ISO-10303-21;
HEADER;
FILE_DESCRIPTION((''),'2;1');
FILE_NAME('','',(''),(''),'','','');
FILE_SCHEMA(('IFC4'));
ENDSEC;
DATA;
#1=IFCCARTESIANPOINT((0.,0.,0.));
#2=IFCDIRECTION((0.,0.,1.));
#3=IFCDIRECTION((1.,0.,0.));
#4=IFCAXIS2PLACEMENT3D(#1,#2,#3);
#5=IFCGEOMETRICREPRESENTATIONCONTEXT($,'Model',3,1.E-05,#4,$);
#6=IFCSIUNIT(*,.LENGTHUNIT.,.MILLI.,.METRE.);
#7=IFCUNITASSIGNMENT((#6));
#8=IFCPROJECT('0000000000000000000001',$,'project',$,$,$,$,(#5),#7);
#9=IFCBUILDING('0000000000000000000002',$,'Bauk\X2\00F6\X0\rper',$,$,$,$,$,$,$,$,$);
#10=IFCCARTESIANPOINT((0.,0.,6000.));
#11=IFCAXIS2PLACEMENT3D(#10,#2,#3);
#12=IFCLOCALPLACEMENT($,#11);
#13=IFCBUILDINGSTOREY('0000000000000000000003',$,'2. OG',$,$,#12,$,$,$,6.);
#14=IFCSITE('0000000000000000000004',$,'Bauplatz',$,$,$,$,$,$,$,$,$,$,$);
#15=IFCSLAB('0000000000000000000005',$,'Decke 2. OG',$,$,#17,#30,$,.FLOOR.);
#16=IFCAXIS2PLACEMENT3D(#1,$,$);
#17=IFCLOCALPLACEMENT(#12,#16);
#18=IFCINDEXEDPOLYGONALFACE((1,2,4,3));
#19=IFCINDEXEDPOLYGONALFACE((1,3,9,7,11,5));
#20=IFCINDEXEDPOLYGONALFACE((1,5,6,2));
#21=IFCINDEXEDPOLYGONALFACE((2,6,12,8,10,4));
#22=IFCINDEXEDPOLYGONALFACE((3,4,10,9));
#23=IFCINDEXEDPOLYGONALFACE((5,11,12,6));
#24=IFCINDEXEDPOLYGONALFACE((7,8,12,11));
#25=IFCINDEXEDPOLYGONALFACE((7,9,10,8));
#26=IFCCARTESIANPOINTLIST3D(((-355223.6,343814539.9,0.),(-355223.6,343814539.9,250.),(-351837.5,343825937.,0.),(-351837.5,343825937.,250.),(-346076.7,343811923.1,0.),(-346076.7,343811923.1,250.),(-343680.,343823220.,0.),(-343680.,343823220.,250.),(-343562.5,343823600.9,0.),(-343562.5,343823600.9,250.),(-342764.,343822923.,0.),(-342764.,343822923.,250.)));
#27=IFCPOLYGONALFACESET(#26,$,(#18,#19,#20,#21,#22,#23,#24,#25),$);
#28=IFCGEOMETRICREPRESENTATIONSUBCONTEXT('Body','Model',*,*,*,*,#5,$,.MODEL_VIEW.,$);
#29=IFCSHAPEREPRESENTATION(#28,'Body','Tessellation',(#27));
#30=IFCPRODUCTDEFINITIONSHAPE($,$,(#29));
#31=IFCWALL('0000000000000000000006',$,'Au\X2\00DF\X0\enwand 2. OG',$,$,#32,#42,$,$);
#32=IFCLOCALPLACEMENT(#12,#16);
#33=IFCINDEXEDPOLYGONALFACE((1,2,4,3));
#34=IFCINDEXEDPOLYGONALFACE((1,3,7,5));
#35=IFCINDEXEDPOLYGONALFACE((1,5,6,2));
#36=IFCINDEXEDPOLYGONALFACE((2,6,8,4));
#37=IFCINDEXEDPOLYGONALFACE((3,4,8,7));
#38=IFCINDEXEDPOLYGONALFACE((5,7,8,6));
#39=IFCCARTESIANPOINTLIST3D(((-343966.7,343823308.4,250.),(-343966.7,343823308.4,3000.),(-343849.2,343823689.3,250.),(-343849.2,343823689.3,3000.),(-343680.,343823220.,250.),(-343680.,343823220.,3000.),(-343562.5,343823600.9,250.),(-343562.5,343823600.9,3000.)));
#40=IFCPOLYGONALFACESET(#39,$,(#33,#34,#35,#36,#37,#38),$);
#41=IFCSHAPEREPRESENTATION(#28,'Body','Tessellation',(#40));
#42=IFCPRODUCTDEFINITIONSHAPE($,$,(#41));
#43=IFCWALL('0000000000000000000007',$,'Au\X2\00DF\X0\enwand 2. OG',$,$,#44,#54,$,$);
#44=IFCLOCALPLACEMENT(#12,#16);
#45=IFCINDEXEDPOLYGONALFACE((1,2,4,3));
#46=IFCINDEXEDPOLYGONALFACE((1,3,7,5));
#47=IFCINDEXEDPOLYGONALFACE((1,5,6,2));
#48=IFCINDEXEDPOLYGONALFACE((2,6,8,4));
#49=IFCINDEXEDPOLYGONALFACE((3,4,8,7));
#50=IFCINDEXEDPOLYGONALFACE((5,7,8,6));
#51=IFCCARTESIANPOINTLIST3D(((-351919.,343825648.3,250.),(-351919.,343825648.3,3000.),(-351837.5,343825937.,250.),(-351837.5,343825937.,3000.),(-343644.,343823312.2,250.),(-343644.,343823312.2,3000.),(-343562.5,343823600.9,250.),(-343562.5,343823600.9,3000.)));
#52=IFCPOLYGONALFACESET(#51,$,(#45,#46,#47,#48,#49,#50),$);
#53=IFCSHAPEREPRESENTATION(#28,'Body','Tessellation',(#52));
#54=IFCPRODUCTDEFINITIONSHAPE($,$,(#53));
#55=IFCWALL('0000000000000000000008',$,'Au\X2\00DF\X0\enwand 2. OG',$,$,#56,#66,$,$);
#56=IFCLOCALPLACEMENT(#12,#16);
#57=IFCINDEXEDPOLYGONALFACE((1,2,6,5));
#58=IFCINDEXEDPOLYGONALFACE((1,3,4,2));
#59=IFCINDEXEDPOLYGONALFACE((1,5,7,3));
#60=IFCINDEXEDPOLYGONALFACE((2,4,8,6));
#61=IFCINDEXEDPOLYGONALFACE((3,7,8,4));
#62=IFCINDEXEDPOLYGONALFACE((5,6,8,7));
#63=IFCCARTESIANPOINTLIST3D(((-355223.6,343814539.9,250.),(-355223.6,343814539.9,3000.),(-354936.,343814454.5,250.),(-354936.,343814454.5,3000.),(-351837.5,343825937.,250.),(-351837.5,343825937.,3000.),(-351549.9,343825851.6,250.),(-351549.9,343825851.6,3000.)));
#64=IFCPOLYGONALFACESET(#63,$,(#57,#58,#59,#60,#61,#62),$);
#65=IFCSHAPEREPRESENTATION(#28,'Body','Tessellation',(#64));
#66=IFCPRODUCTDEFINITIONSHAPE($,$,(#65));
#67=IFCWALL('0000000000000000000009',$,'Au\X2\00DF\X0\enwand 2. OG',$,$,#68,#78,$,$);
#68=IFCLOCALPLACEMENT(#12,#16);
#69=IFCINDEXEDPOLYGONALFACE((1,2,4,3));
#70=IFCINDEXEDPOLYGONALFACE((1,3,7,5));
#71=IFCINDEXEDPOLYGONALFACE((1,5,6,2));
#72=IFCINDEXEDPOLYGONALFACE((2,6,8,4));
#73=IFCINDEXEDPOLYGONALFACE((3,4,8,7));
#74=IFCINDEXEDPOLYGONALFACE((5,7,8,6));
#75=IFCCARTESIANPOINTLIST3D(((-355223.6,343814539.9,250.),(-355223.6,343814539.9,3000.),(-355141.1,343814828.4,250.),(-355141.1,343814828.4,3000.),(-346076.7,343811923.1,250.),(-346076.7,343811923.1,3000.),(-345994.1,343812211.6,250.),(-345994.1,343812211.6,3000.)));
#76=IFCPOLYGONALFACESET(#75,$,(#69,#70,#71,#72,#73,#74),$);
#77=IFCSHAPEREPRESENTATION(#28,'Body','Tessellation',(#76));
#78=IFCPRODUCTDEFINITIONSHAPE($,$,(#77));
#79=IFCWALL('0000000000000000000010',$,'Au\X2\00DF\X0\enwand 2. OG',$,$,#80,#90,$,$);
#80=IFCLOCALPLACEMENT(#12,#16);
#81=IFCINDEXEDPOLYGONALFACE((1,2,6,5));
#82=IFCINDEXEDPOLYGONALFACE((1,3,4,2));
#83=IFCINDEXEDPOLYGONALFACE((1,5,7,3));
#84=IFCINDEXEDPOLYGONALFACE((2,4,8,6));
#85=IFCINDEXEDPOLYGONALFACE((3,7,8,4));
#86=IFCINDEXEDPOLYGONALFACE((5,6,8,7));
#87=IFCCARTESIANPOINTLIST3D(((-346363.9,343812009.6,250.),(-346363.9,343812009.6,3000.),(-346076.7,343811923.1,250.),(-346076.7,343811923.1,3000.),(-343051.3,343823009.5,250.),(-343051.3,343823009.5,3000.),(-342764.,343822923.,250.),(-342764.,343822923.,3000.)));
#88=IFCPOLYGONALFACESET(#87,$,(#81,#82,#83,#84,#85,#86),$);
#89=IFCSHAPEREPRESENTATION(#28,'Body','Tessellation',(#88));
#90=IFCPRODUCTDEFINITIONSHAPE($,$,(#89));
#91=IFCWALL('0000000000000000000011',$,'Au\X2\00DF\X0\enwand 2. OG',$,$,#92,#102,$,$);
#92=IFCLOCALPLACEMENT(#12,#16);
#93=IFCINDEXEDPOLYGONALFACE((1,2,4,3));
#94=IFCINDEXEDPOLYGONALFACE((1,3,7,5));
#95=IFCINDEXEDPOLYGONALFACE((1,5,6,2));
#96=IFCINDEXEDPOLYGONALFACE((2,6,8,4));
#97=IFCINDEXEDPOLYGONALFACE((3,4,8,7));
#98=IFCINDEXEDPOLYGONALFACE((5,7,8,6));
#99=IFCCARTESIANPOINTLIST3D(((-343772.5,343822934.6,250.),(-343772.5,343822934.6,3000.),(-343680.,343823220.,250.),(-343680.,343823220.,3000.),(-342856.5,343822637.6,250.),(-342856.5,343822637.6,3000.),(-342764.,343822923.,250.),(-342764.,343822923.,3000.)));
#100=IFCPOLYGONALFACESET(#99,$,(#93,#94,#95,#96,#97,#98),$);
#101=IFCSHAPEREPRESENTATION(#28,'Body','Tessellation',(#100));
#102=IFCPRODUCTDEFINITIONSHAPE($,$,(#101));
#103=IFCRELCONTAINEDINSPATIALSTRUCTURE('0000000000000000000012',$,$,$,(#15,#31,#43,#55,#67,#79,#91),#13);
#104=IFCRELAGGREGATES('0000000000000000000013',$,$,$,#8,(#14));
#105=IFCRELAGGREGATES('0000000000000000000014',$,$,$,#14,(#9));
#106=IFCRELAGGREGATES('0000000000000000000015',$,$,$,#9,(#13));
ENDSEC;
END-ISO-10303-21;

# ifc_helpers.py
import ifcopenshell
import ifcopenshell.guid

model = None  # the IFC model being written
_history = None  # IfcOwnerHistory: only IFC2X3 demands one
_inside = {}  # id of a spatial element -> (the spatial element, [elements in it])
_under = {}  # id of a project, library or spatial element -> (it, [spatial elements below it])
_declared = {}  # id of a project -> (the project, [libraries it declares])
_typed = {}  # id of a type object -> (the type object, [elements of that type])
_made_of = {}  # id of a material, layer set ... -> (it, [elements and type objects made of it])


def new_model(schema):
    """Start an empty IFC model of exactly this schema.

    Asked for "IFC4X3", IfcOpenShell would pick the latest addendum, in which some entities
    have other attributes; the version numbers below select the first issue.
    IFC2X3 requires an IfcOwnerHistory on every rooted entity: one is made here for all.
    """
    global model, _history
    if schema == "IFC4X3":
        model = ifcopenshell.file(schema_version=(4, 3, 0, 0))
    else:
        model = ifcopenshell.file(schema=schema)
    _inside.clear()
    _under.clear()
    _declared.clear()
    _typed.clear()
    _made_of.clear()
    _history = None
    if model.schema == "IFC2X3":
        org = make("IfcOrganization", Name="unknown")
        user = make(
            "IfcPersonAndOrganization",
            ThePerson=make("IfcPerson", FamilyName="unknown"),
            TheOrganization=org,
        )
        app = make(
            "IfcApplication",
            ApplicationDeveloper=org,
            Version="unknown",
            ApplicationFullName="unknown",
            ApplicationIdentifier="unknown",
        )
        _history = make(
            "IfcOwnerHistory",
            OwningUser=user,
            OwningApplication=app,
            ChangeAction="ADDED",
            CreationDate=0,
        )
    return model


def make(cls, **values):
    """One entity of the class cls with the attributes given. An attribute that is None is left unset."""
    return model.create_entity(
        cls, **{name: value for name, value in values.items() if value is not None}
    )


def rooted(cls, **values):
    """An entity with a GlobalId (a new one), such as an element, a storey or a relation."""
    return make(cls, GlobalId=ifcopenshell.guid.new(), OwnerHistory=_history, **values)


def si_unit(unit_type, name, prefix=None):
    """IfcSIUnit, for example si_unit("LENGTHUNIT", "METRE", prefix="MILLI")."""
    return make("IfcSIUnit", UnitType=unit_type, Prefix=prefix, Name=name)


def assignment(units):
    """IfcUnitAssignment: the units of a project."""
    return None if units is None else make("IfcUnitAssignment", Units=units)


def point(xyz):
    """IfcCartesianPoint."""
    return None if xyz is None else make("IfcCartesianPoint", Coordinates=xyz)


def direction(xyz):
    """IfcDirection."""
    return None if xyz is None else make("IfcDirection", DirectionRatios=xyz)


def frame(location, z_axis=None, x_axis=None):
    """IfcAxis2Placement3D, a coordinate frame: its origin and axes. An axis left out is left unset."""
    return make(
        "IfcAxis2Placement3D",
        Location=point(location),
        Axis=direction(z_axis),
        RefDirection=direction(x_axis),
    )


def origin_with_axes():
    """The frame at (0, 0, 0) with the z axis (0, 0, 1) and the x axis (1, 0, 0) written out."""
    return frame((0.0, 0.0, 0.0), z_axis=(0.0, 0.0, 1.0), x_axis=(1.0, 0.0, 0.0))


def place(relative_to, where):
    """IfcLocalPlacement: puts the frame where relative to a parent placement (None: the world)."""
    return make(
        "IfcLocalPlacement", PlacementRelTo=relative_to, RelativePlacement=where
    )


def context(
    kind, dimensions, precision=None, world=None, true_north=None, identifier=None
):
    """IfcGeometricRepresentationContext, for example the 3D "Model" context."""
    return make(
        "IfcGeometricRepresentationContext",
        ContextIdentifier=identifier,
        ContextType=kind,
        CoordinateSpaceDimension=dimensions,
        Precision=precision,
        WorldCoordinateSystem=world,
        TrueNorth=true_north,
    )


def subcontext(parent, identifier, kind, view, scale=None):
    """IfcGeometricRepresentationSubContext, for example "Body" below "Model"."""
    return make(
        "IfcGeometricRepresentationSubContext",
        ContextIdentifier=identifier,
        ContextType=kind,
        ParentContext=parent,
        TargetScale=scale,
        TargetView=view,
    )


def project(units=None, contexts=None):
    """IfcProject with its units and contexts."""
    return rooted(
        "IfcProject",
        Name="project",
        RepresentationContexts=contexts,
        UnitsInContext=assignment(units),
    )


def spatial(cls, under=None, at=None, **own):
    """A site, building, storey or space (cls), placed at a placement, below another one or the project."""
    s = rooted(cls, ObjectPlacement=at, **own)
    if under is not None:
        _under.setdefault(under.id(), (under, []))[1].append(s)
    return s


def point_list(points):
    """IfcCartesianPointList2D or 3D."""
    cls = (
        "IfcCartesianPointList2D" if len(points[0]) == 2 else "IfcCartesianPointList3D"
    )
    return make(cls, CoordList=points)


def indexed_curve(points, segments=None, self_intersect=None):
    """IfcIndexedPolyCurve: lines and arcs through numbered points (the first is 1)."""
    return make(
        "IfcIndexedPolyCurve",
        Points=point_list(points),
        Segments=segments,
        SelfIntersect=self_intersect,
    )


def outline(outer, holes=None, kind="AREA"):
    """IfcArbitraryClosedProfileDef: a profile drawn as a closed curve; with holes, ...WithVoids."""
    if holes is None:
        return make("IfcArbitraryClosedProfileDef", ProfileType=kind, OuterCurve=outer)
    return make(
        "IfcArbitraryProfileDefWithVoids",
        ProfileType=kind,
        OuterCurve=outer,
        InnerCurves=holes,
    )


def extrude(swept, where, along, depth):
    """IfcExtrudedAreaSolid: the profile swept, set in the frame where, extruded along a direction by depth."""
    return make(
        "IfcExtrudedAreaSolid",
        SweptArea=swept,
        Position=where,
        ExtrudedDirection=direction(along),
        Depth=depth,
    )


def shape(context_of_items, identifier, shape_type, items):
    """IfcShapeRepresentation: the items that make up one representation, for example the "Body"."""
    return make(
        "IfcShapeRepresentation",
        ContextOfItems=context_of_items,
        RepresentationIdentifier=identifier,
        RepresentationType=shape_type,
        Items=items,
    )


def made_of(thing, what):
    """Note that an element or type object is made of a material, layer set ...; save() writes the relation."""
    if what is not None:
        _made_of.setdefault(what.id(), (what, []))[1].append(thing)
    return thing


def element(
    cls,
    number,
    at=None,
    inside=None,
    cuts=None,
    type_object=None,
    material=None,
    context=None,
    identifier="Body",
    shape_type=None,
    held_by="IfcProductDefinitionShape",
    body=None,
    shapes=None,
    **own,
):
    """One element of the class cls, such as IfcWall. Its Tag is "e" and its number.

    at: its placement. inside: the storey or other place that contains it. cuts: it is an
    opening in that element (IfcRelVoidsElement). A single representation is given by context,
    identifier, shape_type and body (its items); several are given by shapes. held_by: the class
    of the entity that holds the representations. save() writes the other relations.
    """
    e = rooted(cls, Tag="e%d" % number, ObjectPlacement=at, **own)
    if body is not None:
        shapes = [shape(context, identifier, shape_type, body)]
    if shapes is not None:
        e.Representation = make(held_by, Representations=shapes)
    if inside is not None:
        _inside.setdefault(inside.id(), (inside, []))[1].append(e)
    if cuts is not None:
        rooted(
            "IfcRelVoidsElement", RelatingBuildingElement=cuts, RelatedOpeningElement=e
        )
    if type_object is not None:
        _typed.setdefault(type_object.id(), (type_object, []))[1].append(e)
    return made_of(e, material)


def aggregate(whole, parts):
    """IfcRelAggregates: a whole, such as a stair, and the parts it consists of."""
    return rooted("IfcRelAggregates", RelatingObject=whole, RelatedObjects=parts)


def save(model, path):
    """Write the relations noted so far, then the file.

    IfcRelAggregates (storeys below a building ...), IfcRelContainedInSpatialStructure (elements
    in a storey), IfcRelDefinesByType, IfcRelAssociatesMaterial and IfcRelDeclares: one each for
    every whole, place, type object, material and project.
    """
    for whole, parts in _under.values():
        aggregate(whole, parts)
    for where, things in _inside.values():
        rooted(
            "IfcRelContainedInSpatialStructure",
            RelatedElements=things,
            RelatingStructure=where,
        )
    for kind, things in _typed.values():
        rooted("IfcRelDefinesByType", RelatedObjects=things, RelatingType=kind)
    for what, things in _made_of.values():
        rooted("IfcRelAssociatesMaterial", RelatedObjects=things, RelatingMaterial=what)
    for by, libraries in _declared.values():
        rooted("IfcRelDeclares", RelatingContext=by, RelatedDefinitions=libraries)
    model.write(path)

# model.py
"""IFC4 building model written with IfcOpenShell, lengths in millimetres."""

from ifc_helpers import new_model, si_unit, frame, origin_with_axes, place, context, subcontext, project, spatial, indexed_curve, outline, extrude, element, save


model = new_model("IFC4")

# Units and contexts
model_context = context("Model", 3, precision=1e-05, world=origin_with_axes())
body_context = subcontext(model_context, "Body", "Model", "MODEL_VIEW")
ifc_project = project(units=[si_unit("LENGTHUNIT", "METRE", prefix="MILLI")], contexts=[model_context])

# Site, building, storey
site = spatial("IfcSite", under=ifc_project, Name="Bauplatz")
building = spatial("IfcBuilding", under=site, Name="Baukörper")
storey_placement = place(None, frame((0.0, 0.0, 6000.0), z_axis=(0.0, 0.0, 1.0), x_axis=(1.0, 0.0, 0.0)))
storey = spatial("IfcBuildingStorey", under=building, at=storey_placement, Name="2. OG", Elevation=6.0)

# Slab
slab_placement = place(storey_placement, origin_with_axes())
element("IfcSlab", 1, at=slab_placement, inside=storey, Name="Decke 2. OG", PredefinedType="FLOOR", context=body_context, shape_type="SweptSolid", body=[
    extrude(outline(indexed_curve([(-343680.0, 343823220.0), (-342764.0, 343822923.0), (-346076.7, 343811923.1), (-355223.6, 343814539.9), (-351837.5, 343825937.0), (-343562.5, 343823600.9)])), None, (0.0, 0.0, 1.0), 250.0),
])

# Walls
wall_1_placement = place(storey_placement, frame((-343680.0, 343823220.0, 250.0), z_axis=(0.0, 0.0, 1.0), x_axis=(0.294713, 0.955586, 0.0)))
element("IfcWall", 2, at=wall_1_placement, inside=storey, Name="Außenwand 2. OG", context=body_context, shape_type="SweptSolid", body=[
    extrude(outline(indexed_curve([(0.0, 0.0), (0.0, 300.0), (398.6, 300.0), (398.6, 0.0), (0.0, 0.0)], self_intersect=False)), origin_with_axes(), (0.0, 0.0, 1.0), 2750.0),
])
wall_2_placement = place(storey_placement, frame((-343562.5, 343823600.9, 250.0), z_axis=(0.0, 0.0, 1.0), x_axis=(-0.962385, 0.271691, 0.0)))
element("IfcWall", 3, at=wall_2_placement, inside=storey, Name="Außenwand 2. OG", context=body_context, shape_type="SweptSolid", body=[
    extrude(outline(indexed_curve([(0.0, 0.0), (0.0, 300.0), (8598.4, 300.0), (8598.4, 0.0), (0.0, 0.0)], self_intersect=False)), origin_with_axes(), (0.0, 0.0, 1.0), 2750.0),
])
wall_3_placement = place(storey_placement, frame((-351837.5, 343825937.0, 250.0), z_axis=(0.0, 0.0, 1.0), x_axis=(-0.284796, -0.958588, 0.0)))
element("IfcWall", 4, at=wall_3_placement, inside=storey, Name="Außenwand 2. OG", context=body_context, shape_type="SweptSolid", body=[
    extrude(outline(indexed_curve([(0.0, 0.0), (0.0, 300.0), (11889.4, 300.0), (11889.4, 0.0), (0.0, 0.0)], self_intersect=False)), origin_with_axes(), (0.0, 0.0, 1.0), 2750.0),
])
wall_4_placement = place(storey_placement, frame((-355223.6, 343814539.9, 250.0), z_axis=(0.0, 0.0, 1.0), x_axis=(0.96143, -0.275051, 0.0)))
element("IfcWall", 5, at=wall_4_placement, inside=storey, Name="Außenwand 2. OG", context=body_context, shape_type="SweptSolid", body=[
    extrude(outline(indexed_curve([(0.0, 0.0), (0.0, 300.0), (9513.9, 300.0), (9513.9, 0.0), (0.0, 0.0)], self_intersect=False)), origin_with_axes(), (0.0, 0.0, 1.0), 2750.0),
])
wall_5_placement = place(storey_placement, frame((-346076.7, 343811923.1, 250.0), z_axis=(0.0, 0.0, 1.0), x_axis=(0.288362, 0.957521, 0.0)))
element("IfcWall", 6, at=wall_5_placement, inside=storey, Name="Außenwand 2. OG", context=body_context, shape_type="SweptSolid", body=[
    extrude(outline(indexed_curve([(0.0, 0.0), (0.0, 300.0), (11487.9, 300.0), (11487.9, 0.0), (0.0, 0.0)], self_intersect=False)), origin_with_axes(), (0.0, 0.0, 1.0), 2750.0),
])
wall_6_placement = place(storey_placement, frame((-342764.0, 343822923.0, 250.0), z_axis=(0.0, 0.0, 1.0), x_axis=(-0.951248, 0.308429, 0.0)))
element("IfcWall", 7, at=wall_6_placement, inside=storey, Name="Außenwand 2. OG", context=body_context, shape_type="SweptSolid", body=[
    extrude(outline(indexed_curve([(0.0, 0.0), (0.0, 300.0), (962.9, 300.0), (962.9, 0.0), (0.0, 0.0)], self_intersect=False)), origin_with_axes(), (0.0, 0.0, 1.0), 2750.0),
])

save(model, "model.ifc")
